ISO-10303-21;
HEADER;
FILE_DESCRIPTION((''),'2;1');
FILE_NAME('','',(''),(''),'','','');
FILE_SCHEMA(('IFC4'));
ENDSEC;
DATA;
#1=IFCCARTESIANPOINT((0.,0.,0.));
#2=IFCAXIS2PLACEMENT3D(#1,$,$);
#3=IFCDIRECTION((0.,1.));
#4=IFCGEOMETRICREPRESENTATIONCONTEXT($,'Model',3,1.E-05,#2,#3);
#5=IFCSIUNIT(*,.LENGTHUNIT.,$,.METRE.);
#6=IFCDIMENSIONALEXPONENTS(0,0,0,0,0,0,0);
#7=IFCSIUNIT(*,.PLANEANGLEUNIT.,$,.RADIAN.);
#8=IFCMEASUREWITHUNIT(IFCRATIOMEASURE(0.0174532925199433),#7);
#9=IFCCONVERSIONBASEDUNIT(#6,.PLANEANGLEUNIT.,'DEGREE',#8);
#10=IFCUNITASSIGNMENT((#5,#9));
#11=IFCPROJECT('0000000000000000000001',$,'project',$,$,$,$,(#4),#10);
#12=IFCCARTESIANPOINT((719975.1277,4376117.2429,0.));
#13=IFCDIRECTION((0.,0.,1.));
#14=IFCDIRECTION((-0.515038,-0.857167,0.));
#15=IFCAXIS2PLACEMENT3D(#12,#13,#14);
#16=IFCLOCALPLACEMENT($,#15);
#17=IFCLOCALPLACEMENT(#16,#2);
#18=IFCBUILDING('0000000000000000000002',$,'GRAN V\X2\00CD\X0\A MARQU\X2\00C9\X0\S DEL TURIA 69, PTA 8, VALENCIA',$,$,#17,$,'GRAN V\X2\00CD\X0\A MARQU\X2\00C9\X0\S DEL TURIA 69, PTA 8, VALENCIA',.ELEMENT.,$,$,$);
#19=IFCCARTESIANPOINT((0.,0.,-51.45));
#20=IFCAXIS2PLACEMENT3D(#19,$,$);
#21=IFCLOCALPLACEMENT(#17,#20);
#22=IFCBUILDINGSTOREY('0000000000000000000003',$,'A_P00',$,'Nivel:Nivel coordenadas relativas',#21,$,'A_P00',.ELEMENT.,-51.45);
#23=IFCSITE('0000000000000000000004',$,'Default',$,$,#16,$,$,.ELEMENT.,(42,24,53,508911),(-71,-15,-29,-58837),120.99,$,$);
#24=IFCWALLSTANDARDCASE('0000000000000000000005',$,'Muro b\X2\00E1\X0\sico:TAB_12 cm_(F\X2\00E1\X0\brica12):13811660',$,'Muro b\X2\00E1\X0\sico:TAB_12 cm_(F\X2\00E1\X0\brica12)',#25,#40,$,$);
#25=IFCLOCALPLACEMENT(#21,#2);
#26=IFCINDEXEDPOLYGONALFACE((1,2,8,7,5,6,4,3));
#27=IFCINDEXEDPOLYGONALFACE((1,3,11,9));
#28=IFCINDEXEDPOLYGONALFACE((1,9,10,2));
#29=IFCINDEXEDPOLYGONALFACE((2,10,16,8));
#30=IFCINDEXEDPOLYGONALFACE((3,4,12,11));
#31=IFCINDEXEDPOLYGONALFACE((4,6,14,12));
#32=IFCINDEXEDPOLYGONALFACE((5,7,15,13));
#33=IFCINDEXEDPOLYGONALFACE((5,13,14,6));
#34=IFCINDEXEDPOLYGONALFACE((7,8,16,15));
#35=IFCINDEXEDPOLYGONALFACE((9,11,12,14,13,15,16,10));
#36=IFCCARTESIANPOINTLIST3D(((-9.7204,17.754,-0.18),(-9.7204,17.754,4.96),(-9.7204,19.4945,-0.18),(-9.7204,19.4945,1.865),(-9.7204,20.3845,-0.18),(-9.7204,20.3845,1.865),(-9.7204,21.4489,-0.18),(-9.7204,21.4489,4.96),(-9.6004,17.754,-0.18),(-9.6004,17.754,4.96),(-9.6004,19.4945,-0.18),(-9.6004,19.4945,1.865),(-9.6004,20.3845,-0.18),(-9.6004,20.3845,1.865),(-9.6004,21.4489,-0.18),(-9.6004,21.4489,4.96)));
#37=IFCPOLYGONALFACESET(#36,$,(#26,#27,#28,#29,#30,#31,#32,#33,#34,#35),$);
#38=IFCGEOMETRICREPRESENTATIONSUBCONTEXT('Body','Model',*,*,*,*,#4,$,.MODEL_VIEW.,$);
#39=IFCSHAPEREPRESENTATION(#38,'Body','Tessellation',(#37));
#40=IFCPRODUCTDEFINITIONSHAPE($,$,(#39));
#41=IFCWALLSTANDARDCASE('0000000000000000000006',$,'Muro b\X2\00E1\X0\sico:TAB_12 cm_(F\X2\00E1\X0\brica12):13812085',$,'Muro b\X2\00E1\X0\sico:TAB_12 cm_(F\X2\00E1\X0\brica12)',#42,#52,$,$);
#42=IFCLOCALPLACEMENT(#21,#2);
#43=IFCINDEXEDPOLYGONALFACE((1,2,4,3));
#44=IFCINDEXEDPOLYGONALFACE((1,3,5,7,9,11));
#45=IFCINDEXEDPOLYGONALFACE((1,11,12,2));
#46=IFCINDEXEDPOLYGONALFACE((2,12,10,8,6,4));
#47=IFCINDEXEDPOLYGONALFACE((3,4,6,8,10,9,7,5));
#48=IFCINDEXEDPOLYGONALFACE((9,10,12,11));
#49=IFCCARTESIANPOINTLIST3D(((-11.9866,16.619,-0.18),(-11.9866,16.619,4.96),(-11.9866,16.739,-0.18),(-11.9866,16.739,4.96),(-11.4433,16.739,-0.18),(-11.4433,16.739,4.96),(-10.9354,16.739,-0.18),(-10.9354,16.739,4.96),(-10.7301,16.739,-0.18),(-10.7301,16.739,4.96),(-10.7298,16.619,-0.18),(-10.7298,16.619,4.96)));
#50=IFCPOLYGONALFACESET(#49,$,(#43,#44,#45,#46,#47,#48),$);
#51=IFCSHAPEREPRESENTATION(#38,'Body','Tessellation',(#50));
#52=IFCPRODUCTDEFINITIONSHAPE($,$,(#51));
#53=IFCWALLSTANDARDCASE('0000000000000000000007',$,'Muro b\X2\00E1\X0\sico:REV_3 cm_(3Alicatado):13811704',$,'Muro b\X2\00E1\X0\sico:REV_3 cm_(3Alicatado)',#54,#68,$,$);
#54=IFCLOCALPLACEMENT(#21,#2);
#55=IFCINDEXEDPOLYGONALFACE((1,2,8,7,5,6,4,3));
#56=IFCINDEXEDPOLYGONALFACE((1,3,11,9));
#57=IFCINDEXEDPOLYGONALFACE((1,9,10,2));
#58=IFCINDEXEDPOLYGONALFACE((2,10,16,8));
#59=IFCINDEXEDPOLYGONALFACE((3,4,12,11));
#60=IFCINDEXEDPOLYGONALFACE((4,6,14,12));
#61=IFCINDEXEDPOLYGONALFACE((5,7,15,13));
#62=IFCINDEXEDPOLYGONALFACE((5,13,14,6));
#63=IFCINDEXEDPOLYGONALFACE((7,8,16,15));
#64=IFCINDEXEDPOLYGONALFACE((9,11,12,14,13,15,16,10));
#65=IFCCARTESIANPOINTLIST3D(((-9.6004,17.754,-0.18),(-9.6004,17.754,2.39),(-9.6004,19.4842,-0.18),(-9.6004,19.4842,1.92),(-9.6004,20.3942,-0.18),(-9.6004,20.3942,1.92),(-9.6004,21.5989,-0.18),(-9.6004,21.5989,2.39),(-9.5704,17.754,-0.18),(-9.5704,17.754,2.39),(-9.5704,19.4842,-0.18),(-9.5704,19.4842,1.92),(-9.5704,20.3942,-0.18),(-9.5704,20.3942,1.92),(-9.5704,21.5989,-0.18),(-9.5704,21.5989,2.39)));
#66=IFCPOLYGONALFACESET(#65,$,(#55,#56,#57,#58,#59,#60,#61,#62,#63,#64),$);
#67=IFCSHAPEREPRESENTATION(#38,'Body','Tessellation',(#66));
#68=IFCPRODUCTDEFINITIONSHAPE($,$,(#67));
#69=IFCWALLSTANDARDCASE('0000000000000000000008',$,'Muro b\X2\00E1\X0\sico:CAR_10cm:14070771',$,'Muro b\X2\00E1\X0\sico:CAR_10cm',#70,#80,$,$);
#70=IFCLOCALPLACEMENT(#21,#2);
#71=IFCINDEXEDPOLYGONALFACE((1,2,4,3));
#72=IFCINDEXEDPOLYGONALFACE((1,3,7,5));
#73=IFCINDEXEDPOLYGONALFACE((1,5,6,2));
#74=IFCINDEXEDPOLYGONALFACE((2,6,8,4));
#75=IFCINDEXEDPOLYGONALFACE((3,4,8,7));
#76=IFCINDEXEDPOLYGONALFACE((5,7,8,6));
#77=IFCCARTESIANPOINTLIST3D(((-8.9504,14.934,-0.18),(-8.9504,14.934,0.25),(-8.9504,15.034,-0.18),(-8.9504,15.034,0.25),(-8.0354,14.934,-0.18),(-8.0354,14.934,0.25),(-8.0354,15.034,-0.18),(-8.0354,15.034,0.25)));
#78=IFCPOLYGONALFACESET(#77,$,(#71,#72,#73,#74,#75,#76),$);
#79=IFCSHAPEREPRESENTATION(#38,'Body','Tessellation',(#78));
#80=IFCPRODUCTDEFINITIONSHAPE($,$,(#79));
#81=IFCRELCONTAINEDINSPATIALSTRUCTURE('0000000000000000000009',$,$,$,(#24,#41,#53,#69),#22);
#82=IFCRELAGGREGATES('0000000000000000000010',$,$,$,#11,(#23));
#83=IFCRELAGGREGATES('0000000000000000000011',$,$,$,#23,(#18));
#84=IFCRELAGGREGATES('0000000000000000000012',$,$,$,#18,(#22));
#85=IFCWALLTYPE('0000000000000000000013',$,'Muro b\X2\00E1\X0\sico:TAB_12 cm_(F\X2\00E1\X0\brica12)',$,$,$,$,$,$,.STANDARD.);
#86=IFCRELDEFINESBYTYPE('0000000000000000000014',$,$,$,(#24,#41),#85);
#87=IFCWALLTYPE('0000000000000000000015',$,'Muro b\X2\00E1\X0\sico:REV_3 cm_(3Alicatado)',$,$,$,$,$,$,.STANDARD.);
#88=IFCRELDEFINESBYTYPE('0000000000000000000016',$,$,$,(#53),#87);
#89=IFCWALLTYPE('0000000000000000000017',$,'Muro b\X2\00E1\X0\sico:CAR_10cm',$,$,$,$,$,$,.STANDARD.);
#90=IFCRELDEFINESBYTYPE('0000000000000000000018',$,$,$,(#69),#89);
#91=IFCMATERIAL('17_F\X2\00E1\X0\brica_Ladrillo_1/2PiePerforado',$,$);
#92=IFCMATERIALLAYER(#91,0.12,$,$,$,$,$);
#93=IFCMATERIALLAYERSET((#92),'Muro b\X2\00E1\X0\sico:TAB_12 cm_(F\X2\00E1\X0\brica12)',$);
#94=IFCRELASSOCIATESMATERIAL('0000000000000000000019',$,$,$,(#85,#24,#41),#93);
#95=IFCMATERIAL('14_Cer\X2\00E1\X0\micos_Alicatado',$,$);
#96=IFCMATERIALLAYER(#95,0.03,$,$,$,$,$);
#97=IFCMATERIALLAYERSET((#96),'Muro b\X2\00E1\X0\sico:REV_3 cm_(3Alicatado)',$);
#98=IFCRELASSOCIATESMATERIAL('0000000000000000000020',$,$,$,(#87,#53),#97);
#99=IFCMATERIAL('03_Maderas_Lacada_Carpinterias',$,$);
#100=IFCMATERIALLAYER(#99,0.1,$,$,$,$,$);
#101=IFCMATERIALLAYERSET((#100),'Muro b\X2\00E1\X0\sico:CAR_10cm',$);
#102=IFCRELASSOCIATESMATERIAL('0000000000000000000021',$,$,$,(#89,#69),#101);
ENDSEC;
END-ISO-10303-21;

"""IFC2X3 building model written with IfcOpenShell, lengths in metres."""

from ifc_helpers import new_model, entity, si_unit, converted_unit, direction, frame, frame_2d, origin, place, context, subcontext, project, spatial, polyline, rectangle, outline, extrude, material, layer, layer_set, layer_usage, type_object, element, save


model = new_model("IFC2X3")

# Units and contexts
model_context = context("Model", 3, precision=1e-05, world=origin(), true_north=direction((0.0, 1.0)))
body_context = subcontext(model_context, "Body", "Model", "MODEL_VIEW")
ifc_project = project(units=[si_unit("LENGTHUNIT", "METRE"), converted_unit("PLANEANGLEUNIT", "DEGREE", entity("IfcRatioMeasure", 0.0174532925199433), si_unit("PLANEANGLEUNIT", "RADIAN"), dimensions=[0, 0, 0, 0, 0, 0, 0])], contexts=[model_context])

# Site, building, storey
site_placement = place(None, frame((719975.1277, 4376117.2429, 0.0), z_axis=(0.0, 0.0, 1.0), x_axis=(-0.515038, -0.857167, 0.0)))
site = spatial("IfcSite", under=ifc_project, at=site_placement, Name="Default", CompositionType="ELEMENT", RefLatitude=(42, 24, 53, 508911), RefLongitude=(-71, -15, -29, -58837), RefElevation=120.99)
building_placement = place(site_placement, origin())
building = spatial("IfcBuilding", under=site, at=building_placement, Name="GRAN VÍA MARQUÉS DEL TURIA 69, PTA 8, VALENCIA", LongName="GRAN VÍA MARQUÉS DEL TURIA 69, PTA 8, VALENCIA", CompositionType="ELEMENT")
storey_placement = place(building_placement, frame((0.0, 0.0, -51.45)))
storey = spatial("IfcBuildingStorey", under=building, at=storey_placement, Name="A_P00", ObjectType="Nivel:Nivel coordenadas relativas", LongName="A_P00", CompositionType="ELEMENT", Elevation=-51.45)

# Shared definitions
ifc_material_1 = material(Name="03_Maderas_Lacada_Carpinterias")

# Wall, opening
ifc_material_2 = material(Name="17_Fábrica_Ladrillo_1/2PiePerforado")
ifc_layer_1 = layer(ifc_material_2, 0.12)
ifc_layer_set_1 = layer_set([ifc_layer_1], Name="Muro básico:TAB_12 cm_(Fábrica12)")
ifc_layer_usage_1 = layer_usage(ifc_layer_set_1, "AXIS2", "NEGATIVE", 0.06)
wall_type_1 = type_object("IfcWallType", Name="Muro básico:TAB_12 cm_(Fábrica12)", PredefinedType="STANDARD", material=ifc_layer_set_1)
wall_1_placement = place(storey_placement, frame((-9.6604, 17.754, -0.18), z_axis=(0.0, 0.0, 1.0), x_axis=(0.0, 1.0, 0.0)))
wall_1 = element("IfcWallStandardCase", 1, at=wall_1_placement, inside=storey, type_object=wall_type_1, material=ifc_layer_usage_1, Name="Muro básico:TAB_12 cm_(Fábrica12):13811660", ObjectType="Muro básico:TAB_12 cm_(Fábrica12)", context=body_context, shape_type="SweptSolid", body=[
    extrude(rectangle(XDim=3.6949, YDim=0.12, at=frame_2d((1.8474, 0.0), x_axis=(-1.0, 0.0))), origin(), (0.0, 0.0, 1.0), 5.14),
])
opening_1_placement = place(wall_1_placement, frame((2.6304, 0.06, 0.0)))
element("IfcOpeningElement", 2, at=opening_1_placement, cuts=wall_1, ObjectType="Opening", context=body_context, shape_type="SweptSolid", body=[
    extrude(rectangle(XDim=2.045, YDim=0.89, at=frame_2d((1.0225, 0.445), x_axis=(-1.0, 0.0))), frame((0.0, 0.0, 0.0), z_axis=(0.0, -1.0, 0.0), x_axis=(0.0, 0.0, 1.0)), (0.0, 0.0, 1.0), 0.12),
])

# Wall
ifc_layer_usage_2 = layer_usage(ifc_layer_set_1, "AXIS2", "POSITIVE", -0.06)
wall_2_placement = place(storey_placement, frame((-10.7298, 16.679, -0.18), z_axis=(0.0, 0.0, 1.0), x_axis=(-1.0, 0.0, 0.0)))
element("IfcWallStandardCase", 3, at=wall_2_placement, inside=storey, type_object=wall_type_1, material=ifc_layer_usage_2, Name="Muro básico:TAB_12 cm_(Fábrica12):13812085", ObjectType="Muro básico:TAB_12 cm_(Fábrica12)", context=body_context, shape_type="SweptSolid", body=[
    extrude(outline(polyline([(1.2568, -0.06), (1.2568, 0.06), (0.0, 0.06), (0.0003, -0.06), (0.2056, -0.06), (0.7136, -0.06), (1.2568, -0.06)])), origin(), (0.0, 0.0, 1.0), 5.14),
])

# Wall, opening
ifc_material_3 = material(Name="14_Cerámicos_Alicatado")
ifc_layer_2 = layer(ifc_material_3, 0.03)
ifc_layer_set_2 = layer_set([ifc_layer_2], Name="Muro básico:REV_3 cm_(3Alicatado)")
ifc_layer_usage_3 = layer_usage(ifc_layer_set_2, "AXIS2", "NEGATIVE", 0.015)
wall_type_2 = type_object("IfcWallType", Name="Muro básico:REV_3 cm_(3Alicatado)", PredefinedType="STANDARD", material=ifc_layer_set_2)
wall_3_placement = place(storey_placement, frame((-9.5854, 17.754, -0.18), z_axis=(0.0, 0.0, 1.0), x_axis=(0.0, 1.0, 0.0)))
wall_3 = element("IfcWallStandardCase", 4, at=wall_3_placement, inside=storey, type_object=wall_type_2, material=ifc_layer_usage_3, Name="Muro básico:REV_3 cm_(3Alicatado):13811704", ObjectType="Muro básico:REV_3 cm_(3Alicatado)", context=body_context, shape_type="SweptSolid", body=[
    extrude(rectangle(XDim=3.8449, YDim=0.03, at=frame_2d((1.9224, 0.0), x_axis=(-1.0, 0.0))), origin(), (0.0, 0.0, 1.0), 2.57),
])
opening_2_placement = place(wall_3_placement, origin())
element("IfcOpeningElement", 5, at=opening_2_placement, cuts=wall_3, ObjectType="Opening", context=body_context, shape_type="SweptSolid", body=[
    extrude(rectangle(XDim=2.1, YDim=0.91, at=frame_2d((0.0, 0.0), x_axis=(1.0, 0.0))), frame((2.1852, -0.015, 1.05), z_axis=(0.0, 1.0, 0.0), x_axis=(0.0, 0.0, -1.0)), (0.0, 0.0, 1.0), 0.03),
])

# Wall
ifc_layer_3 = layer(ifc_material_1, 0.1)
ifc_layer_set_3 = layer_set([ifc_layer_3], Name="Muro básico:CAR_10cm")
ifc_layer_usage_4 = layer_usage(ifc_layer_set_3, "AXIS2", "NEGATIVE", 0.05)
wall_type_3 = type_object("IfcWallType", Name="Muro básico:CAR_10cm", PredefinedType="STANDARD", material=ifc_layer_set_3)
wall_4_placement = place(storey_placement, frame((-8.9504, 14.984, -0.18)))
element("IfcWallStandardCase", 6, at=wall_4_placement, inside=storey, type_object=wall_type_3, material=ifc_layer_usage_4, Name="Muro básico:CAR_10cm:14070771", ObjectType="Muro básico:CAR_10cm", context=body_context, shape_type="SweptSolid", body=[
    extrude(rectangle(XDim=0.915, YDim=0.1, at=frame_2d((0.4575, 0.0), x_axis=(-1.0, 0.0))), origin(), (0.0, 0.0, 1.0), 0.43),
])

save(model, "model.ifc")
